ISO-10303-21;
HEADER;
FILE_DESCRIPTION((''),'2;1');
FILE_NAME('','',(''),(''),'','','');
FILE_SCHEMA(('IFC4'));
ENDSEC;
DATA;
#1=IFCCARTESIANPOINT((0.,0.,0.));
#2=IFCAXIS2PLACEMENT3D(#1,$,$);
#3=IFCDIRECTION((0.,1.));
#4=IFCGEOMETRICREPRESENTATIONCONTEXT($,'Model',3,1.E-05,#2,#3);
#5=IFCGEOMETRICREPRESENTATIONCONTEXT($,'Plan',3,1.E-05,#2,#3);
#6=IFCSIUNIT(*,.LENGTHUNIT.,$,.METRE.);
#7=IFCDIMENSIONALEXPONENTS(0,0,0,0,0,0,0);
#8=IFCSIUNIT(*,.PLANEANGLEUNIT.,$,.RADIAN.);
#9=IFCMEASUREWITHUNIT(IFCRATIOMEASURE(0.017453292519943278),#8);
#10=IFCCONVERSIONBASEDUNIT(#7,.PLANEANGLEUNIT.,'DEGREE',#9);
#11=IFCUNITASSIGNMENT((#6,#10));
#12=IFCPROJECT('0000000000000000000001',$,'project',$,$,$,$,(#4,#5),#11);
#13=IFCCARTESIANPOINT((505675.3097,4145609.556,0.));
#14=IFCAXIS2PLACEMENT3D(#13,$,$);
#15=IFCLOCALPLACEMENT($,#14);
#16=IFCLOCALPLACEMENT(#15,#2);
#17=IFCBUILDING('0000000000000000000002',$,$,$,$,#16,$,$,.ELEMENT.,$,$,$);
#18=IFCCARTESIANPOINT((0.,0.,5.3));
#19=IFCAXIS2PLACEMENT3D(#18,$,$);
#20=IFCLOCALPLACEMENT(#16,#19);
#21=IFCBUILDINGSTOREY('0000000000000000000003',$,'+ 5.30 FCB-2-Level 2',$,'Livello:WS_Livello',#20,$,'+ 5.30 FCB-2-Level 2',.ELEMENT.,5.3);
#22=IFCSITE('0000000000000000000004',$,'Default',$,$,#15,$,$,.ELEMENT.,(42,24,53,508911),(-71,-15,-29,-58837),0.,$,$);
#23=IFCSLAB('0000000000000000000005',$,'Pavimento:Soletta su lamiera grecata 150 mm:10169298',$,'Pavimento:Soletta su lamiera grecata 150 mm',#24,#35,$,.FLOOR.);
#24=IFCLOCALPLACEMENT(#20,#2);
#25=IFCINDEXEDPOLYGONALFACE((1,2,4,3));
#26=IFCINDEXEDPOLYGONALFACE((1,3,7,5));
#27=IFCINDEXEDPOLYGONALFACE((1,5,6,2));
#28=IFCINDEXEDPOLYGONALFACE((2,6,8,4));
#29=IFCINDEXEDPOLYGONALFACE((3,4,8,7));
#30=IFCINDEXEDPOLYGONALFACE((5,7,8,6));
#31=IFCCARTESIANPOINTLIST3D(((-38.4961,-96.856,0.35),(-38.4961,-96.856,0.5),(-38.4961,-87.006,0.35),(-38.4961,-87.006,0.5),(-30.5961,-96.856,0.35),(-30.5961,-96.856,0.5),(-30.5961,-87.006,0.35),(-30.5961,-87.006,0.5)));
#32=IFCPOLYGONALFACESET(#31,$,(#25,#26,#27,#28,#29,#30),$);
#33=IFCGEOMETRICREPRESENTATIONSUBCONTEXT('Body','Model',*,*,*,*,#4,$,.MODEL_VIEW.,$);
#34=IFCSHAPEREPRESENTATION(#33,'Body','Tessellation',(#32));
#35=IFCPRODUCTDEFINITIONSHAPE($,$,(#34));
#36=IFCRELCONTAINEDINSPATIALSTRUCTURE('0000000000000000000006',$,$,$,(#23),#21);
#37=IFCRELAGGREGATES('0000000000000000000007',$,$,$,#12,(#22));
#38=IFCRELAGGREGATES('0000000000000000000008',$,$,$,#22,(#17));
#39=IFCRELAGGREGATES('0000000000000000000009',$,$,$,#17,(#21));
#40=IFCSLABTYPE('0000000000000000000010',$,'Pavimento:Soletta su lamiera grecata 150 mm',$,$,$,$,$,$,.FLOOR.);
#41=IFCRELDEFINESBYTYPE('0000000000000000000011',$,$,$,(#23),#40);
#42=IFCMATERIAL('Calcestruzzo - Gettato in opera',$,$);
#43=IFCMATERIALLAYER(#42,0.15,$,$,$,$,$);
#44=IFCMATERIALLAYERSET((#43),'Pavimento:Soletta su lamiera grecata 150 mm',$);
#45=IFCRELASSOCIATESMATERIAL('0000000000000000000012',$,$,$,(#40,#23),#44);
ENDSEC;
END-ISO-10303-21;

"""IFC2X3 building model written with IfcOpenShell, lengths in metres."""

from ifc_helpers import new_model, entity, si_unit, converted_unit, direction, frame, frame_2d, origin, place, context, subcontext, project, spatial, rectangle, extrude, material, layer, layer_set, layer_usage, type_object, element, save


model = new_model("IFC2X3")

# Units and contexts
model_context = context("Model", 3, precision=1e-05, world=origin(), true_north=direction((0.0, 1.0)))
plan_context = context("Plan", 3, precision=1e-05, world=origin(), true_north=direction((0.0, 1.0)))
body_context = subcontext(model_context, "Body", "Model", "MODEL_VIEW")
ifc_project = project(units=[si_unit("LENGTHUNIT", "METRE"), converted_unit("PLANEANGLEUNIT", "DEGREE", entity("IfcRatioMeasure", 0.017453292519943278), si_unit("PLANEANGLEUNIT", "RADIAN"), dimensions=[0, 0, 0, 0, 0, 0, 0])], contexts=[model_context, plan_context])

# Site, building, storey
site_placement = place(None, frame((505675.3097, 4145609.556, 0.0)))
site = spatial("IfcSite", under=ifc_project, at=site_placement, Name="Default", CompositionType="ELEMENT", RefLatitude=(42, 24, 53, 508911), RefLongitude=(-71, -15, -29, -58837), RefElevation=0.0)
building_placement = place(site_placement, origin())
building = spatial("IfcBuilding", under=site, at=building_placement, CompositionType="ELEMENT")
storey_placement = place(building_placement, frame((0.0, 0.0, 5.3)))
storey = spatial("IfcBuildingStorey", under=building, at=storey_placement, Name="+ 5.30 FCB-2-Level 2", ObjectType="Livello:WS_Livello", LongName="+ 5.30 FCB-2-Level 2", CompositionType="ELEMENT", Elevation=5.3)

# Slab
ifc_material = material(Name="Calcestruzzo - Gettato in opera")
ifc_layer = layer(ifc_material, 0.15)
ifc_layer_set = layer_set([ifc_layer], Name="Pavimento:Soletta su lamiera grecata 150 mm")
ifc_layer_usage = layer_usage(ifc_layer_set, "AXIS3", "POSITIVE", 0.0)
slab_type = type_object("IfcSlabType", Name="Pavimento:Soletta su lamiera grecata 150 mm", PredefinedType="FLOOR", material=ifc_layer_set)
slab_1_placement = place(storey_placement, frame((-38.4961, -96.856, 0.35)))
element("IfcSlab", 1, at=slab_1_placement, inside=storey, type_object=slab_type, material=ifc_layer_usage, Name="Pavimento:Soletta su lamiera grecata 150 mm:10169298", ObjectType="Pavimento:Soletta su lamiera grecata 150 mm", PredefinedType="FLOOR", context=body_context, shape_type="SweptSolid", body=[
    extrude(rectangle(XDim=9.85, YDim=7.9, at=frame_2d((0.0, -17.225), x_axis=(0.0, -1.0))), frame((3.95, 22.1501, 0.15), z_axis=(0.0, 0.0, -1.0), x_axis=(-1.0, 0.0, 0.0)), (0.0, 0.0, 1.0), 0.15),
])

save(model, "model.ifc")
